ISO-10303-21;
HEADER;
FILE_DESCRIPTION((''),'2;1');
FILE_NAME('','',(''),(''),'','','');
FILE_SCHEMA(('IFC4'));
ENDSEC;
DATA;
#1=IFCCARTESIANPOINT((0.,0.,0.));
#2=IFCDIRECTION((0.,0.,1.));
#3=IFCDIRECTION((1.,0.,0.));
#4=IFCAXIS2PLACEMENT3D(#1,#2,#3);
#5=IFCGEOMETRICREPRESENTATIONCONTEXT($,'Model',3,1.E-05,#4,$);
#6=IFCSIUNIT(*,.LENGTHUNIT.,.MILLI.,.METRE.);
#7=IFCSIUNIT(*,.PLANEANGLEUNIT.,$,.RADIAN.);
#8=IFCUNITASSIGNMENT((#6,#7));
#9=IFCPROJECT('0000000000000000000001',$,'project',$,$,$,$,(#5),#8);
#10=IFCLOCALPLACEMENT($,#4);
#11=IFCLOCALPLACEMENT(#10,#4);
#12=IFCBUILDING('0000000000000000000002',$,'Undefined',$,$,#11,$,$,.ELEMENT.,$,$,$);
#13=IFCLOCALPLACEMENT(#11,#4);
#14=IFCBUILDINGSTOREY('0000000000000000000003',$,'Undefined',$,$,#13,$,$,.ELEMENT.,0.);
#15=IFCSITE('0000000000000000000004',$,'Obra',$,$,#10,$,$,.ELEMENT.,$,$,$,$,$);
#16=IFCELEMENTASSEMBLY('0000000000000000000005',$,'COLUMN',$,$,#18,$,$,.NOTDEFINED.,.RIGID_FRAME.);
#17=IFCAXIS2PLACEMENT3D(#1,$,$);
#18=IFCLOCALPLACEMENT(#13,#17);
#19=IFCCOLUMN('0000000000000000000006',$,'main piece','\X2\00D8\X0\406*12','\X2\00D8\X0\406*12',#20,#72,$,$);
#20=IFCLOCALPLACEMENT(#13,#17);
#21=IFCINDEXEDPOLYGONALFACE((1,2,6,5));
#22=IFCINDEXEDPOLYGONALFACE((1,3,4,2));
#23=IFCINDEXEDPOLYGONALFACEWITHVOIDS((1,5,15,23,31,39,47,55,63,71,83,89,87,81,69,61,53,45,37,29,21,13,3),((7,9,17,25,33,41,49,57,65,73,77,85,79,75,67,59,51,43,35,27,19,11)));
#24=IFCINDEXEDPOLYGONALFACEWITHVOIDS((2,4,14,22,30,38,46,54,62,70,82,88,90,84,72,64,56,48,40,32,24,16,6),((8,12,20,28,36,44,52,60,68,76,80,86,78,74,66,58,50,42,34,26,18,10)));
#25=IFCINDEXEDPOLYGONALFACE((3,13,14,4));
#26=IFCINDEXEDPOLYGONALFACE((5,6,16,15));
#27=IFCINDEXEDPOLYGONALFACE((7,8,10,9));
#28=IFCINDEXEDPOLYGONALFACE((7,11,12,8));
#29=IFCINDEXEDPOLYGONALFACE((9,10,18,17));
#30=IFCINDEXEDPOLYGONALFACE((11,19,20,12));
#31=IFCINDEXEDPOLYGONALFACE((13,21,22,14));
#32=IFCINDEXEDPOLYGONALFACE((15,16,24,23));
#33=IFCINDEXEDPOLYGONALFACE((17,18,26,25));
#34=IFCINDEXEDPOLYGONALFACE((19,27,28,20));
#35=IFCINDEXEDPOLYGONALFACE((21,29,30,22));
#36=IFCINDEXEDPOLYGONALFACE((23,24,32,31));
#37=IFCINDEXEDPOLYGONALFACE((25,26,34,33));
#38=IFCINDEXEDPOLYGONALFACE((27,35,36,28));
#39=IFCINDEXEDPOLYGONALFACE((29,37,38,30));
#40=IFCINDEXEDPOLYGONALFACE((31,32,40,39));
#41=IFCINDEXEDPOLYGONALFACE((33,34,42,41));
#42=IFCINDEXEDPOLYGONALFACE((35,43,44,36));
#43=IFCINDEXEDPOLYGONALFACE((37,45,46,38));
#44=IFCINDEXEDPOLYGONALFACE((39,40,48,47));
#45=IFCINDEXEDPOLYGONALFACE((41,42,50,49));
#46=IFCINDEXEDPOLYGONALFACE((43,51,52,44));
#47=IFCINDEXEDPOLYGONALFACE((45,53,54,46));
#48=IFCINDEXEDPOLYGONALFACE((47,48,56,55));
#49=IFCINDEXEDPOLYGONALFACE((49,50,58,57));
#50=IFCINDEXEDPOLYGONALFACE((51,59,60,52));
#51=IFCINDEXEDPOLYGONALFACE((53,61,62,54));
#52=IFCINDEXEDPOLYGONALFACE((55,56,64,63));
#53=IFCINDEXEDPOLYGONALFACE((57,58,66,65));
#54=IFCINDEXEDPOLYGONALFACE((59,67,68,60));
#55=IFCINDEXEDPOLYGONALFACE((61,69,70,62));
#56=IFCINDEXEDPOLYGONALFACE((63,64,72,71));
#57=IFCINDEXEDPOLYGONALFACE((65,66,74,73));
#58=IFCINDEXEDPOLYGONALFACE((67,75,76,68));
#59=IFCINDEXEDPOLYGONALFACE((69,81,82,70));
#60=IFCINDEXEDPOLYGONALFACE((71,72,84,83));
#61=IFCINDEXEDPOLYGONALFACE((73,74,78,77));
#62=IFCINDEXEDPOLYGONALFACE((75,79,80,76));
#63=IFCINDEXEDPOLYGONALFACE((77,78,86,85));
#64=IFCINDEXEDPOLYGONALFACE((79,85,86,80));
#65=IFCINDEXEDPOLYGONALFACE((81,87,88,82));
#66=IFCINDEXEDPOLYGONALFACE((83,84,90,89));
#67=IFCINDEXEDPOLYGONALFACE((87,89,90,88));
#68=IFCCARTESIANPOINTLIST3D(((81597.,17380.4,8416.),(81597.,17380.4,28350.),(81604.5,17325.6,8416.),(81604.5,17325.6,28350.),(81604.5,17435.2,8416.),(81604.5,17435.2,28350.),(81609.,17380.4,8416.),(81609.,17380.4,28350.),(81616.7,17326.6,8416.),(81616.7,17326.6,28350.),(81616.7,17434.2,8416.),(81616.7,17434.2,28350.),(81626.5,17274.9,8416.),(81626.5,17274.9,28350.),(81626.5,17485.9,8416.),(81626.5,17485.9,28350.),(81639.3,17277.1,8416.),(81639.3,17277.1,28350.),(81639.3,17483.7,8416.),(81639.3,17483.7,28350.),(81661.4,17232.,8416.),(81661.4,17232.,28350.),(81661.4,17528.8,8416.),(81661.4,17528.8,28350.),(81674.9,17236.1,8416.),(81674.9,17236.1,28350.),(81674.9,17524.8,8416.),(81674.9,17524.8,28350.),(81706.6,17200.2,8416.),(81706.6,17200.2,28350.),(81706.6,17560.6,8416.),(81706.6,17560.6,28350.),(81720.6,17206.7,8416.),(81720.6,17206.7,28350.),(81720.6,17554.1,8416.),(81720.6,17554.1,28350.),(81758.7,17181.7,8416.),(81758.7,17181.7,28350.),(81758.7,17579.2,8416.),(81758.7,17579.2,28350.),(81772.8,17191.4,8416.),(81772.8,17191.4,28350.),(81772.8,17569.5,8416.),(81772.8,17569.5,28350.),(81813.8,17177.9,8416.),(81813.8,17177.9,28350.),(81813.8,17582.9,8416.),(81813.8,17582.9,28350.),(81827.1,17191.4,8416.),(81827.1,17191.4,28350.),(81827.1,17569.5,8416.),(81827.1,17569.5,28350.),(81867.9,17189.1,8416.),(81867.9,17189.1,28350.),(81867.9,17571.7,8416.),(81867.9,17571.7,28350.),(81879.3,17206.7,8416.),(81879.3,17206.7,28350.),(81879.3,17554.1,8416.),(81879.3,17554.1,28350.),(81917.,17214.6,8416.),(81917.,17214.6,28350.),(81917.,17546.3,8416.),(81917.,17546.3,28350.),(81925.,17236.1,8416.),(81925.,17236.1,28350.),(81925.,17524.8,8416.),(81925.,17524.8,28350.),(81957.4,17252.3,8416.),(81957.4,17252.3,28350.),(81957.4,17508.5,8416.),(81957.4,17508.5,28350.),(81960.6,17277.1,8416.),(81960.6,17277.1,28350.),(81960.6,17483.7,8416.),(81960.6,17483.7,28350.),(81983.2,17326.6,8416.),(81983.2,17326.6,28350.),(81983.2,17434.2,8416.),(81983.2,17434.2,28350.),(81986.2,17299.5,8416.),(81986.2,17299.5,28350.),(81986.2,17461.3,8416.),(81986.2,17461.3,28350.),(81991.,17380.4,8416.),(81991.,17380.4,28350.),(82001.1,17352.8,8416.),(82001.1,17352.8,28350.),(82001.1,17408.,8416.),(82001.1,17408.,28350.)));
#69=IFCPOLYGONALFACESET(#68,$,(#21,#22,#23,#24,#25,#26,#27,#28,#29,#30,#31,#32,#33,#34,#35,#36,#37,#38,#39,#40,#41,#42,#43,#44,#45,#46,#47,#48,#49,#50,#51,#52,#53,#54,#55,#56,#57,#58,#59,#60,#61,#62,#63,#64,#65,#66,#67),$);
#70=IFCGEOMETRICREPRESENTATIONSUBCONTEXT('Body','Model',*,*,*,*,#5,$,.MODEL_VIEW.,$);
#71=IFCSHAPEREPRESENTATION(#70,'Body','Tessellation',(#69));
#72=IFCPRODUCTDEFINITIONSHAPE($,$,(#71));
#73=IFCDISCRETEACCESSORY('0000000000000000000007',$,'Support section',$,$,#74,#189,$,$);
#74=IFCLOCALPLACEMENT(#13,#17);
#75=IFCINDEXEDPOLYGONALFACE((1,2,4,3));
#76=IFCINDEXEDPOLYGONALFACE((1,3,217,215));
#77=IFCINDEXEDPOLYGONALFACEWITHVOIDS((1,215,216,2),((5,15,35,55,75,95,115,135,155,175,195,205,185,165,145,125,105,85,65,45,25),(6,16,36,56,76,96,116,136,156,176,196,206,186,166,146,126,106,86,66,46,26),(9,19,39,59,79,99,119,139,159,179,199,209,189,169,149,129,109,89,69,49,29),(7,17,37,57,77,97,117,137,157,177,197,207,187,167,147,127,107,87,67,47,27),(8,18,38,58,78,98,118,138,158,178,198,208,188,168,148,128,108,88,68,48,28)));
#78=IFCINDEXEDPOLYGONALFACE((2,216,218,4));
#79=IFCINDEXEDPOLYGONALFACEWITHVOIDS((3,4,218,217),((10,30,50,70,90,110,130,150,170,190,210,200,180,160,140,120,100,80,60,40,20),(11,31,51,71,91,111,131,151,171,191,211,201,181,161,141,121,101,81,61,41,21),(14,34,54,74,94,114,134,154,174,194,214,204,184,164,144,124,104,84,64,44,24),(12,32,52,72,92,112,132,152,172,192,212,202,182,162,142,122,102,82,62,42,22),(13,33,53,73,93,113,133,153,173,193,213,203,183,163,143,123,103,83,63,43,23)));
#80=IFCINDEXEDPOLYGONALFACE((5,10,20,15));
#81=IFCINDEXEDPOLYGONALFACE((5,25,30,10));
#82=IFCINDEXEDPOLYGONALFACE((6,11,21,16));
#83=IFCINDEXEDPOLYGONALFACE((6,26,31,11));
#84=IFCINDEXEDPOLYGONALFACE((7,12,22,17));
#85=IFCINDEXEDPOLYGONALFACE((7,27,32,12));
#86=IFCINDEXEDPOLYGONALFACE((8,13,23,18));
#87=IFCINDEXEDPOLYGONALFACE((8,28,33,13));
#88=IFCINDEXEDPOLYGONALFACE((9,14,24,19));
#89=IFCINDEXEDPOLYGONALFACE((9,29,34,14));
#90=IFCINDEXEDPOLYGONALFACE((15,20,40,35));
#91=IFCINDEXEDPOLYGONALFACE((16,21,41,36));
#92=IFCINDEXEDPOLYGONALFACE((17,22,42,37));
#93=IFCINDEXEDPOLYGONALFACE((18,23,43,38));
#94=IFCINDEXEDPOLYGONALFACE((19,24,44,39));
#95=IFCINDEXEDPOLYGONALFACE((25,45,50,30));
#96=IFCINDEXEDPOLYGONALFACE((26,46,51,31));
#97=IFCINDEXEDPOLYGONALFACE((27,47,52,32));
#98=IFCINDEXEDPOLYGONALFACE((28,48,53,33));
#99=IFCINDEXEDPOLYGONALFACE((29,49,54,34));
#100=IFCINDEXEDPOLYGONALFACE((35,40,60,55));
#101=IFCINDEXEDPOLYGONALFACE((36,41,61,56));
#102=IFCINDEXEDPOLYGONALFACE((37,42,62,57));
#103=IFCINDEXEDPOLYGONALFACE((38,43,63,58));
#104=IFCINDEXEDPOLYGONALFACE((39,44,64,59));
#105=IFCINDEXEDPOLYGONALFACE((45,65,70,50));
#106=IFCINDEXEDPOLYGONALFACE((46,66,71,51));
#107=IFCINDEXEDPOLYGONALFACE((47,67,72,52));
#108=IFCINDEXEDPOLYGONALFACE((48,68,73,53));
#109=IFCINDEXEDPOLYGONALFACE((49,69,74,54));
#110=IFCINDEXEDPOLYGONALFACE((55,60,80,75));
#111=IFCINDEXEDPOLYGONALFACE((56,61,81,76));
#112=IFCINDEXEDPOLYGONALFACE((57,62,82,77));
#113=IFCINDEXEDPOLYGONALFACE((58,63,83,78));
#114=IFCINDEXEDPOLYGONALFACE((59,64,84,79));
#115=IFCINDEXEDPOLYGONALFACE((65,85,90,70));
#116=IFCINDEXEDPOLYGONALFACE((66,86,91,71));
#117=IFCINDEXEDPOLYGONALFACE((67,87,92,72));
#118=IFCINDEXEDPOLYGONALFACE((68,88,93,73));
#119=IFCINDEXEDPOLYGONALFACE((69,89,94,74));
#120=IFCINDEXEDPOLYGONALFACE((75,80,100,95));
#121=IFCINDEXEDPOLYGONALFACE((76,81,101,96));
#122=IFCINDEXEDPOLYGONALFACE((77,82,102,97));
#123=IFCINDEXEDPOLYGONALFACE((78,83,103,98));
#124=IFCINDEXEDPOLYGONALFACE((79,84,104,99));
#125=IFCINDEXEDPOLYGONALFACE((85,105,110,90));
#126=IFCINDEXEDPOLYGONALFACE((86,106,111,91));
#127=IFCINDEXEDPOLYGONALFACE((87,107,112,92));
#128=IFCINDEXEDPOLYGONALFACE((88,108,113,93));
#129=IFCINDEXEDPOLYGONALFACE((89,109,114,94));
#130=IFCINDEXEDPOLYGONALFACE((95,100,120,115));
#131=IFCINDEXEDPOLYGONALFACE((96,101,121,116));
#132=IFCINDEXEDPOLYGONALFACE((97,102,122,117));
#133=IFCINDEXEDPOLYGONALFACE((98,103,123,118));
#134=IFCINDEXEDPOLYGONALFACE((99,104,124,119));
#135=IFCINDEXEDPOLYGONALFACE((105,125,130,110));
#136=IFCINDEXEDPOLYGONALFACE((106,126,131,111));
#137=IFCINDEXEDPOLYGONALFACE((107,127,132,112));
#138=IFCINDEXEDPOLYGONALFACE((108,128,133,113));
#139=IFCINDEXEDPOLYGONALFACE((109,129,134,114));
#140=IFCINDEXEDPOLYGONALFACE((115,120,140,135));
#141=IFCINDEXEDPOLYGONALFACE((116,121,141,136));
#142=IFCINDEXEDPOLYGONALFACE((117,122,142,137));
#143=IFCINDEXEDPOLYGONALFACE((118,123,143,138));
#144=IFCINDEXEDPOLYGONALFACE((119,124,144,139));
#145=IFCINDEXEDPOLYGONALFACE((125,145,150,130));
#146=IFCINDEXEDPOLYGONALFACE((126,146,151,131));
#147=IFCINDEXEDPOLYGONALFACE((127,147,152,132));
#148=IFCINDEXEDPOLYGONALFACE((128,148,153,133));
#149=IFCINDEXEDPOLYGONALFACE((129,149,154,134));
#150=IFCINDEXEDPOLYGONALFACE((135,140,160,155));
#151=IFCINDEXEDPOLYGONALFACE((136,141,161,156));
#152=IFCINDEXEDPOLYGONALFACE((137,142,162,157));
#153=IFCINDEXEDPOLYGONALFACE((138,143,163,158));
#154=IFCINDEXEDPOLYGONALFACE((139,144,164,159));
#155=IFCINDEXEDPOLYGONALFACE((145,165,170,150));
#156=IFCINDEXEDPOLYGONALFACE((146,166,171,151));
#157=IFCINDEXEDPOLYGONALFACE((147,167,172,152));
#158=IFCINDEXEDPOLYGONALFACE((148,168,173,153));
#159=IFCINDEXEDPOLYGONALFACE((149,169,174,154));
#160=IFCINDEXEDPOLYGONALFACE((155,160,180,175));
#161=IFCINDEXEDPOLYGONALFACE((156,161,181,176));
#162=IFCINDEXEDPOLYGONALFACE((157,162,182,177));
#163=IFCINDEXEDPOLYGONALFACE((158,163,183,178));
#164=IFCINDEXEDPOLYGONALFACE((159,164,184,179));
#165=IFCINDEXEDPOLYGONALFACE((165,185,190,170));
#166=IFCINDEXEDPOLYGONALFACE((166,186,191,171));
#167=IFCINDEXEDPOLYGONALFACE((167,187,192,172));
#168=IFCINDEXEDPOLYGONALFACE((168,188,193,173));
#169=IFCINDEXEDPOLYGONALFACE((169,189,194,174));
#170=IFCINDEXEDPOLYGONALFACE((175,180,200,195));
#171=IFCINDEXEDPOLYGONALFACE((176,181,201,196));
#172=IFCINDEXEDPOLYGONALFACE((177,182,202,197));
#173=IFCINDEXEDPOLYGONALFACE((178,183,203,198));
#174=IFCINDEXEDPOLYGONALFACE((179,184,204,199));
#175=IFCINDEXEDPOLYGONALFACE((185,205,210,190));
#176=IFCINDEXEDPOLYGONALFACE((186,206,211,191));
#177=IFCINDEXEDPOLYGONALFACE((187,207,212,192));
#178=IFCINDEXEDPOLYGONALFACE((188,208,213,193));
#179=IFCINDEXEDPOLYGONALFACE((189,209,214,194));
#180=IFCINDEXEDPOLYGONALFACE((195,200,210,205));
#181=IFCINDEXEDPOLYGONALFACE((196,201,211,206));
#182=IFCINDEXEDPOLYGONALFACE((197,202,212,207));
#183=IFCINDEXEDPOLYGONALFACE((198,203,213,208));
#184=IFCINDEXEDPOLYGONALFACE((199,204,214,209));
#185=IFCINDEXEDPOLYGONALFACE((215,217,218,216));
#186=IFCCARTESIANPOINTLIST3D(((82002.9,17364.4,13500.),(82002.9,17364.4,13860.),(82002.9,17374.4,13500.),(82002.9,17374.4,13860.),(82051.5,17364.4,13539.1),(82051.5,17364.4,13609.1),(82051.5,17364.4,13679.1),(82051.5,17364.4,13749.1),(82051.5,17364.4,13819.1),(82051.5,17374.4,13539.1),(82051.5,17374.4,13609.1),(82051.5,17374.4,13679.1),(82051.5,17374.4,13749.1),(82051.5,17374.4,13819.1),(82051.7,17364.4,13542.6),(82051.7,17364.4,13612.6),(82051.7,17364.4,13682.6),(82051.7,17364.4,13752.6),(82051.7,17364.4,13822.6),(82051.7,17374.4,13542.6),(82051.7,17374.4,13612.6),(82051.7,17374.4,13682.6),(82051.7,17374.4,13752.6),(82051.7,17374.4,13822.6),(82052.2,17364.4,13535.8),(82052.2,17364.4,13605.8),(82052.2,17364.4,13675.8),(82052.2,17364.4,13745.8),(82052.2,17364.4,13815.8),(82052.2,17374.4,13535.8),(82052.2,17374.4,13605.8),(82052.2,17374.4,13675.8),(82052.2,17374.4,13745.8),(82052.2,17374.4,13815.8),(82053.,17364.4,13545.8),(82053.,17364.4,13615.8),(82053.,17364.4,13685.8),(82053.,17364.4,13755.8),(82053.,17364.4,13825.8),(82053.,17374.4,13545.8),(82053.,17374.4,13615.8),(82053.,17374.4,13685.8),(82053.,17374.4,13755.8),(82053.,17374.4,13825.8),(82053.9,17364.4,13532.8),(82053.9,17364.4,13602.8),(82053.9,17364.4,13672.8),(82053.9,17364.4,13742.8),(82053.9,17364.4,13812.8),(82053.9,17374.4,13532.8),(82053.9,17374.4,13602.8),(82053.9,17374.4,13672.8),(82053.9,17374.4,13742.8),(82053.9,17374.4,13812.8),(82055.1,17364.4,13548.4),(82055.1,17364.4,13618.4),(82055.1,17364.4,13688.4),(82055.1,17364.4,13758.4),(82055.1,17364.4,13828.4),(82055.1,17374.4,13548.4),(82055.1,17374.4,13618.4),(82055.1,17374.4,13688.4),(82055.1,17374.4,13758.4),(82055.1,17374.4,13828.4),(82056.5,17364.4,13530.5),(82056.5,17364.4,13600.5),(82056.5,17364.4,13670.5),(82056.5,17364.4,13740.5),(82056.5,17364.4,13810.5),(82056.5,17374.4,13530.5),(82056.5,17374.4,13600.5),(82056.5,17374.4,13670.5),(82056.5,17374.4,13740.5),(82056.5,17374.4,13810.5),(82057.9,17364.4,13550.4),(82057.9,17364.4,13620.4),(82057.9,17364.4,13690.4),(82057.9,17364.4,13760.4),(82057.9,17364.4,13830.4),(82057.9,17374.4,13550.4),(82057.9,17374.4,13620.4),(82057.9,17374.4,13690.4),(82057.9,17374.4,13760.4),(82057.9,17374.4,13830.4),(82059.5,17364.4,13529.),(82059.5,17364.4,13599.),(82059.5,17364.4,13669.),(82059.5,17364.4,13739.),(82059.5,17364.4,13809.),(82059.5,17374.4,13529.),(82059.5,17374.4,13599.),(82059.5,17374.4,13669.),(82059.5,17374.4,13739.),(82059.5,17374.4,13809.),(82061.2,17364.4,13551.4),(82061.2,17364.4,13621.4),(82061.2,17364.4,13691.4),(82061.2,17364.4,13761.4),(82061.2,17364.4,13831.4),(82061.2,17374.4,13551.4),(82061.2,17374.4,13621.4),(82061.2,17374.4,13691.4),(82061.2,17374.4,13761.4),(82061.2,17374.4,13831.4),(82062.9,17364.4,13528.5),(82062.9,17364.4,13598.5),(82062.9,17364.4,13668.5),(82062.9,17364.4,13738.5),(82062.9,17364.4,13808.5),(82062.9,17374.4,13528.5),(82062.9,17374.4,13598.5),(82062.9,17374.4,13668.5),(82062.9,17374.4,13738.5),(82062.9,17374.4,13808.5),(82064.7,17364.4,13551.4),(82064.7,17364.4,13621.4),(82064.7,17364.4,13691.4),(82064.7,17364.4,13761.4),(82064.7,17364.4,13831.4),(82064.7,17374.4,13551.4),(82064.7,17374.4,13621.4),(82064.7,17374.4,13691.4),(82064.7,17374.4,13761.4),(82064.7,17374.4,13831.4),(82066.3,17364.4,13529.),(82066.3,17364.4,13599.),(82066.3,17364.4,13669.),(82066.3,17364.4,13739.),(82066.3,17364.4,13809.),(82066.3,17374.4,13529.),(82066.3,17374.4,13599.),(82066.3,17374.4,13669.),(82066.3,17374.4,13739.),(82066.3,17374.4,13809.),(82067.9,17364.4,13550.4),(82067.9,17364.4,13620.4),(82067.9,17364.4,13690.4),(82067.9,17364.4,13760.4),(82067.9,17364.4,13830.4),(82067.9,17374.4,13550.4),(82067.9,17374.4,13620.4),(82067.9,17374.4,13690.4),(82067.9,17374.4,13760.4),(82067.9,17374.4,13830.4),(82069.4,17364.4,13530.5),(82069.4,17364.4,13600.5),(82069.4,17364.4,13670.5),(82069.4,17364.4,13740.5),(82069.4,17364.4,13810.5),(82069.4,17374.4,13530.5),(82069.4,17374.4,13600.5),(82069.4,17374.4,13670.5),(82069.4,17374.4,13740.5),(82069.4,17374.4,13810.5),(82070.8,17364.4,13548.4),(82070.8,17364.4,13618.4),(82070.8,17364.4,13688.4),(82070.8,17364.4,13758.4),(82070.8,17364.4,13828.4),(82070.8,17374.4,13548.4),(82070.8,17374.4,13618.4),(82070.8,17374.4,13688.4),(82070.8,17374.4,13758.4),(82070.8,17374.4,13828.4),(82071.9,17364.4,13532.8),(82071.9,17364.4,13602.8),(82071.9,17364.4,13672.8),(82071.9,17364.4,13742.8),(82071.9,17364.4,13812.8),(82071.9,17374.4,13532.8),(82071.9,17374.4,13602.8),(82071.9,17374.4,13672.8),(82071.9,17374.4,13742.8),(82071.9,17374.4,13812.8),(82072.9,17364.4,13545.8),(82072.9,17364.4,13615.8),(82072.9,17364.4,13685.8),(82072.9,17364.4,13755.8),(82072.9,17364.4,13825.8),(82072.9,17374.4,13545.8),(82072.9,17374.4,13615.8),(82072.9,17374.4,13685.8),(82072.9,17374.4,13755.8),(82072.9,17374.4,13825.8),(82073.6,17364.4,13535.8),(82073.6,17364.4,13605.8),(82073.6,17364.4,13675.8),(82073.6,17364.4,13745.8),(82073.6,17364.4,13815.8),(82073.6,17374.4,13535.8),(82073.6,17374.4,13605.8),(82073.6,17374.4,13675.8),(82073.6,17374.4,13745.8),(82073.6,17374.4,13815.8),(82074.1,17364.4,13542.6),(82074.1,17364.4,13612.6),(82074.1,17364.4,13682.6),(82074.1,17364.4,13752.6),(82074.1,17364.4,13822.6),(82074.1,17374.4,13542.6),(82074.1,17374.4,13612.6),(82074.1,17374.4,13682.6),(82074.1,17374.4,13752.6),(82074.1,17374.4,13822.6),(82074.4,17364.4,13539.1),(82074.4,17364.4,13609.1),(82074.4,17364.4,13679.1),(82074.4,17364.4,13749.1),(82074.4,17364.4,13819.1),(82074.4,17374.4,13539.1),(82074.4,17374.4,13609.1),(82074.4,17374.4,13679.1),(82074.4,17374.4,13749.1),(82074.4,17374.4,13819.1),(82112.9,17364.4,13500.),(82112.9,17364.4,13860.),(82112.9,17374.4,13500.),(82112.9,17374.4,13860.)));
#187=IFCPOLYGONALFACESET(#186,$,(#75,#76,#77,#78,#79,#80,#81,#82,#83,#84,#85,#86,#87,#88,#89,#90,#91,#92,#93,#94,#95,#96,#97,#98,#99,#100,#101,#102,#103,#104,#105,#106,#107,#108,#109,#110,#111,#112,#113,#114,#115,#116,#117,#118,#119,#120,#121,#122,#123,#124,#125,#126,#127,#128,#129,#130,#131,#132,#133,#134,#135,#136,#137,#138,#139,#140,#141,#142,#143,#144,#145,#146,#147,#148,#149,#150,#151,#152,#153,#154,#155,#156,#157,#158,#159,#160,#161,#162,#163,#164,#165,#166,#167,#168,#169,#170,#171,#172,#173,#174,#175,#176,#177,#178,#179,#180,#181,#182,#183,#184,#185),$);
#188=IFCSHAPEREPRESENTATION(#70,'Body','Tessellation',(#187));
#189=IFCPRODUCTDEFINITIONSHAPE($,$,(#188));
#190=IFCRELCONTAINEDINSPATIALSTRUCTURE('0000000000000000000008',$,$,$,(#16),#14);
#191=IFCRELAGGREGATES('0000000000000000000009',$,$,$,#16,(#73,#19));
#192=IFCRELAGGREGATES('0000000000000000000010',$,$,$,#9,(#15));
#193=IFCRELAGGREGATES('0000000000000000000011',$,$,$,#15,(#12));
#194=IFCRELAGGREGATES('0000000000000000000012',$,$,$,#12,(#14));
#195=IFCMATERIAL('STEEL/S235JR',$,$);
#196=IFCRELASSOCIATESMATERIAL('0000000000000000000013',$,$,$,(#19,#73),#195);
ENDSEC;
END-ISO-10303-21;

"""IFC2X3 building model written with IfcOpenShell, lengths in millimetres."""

from ifc_helpers import new_model, si_unit, frame, origin_with_axes, origin_2d_with_axis, place, context, subcontext, project, spatial, rectangle, circle, hollow_circle, extrude, clip, halfspace, source, transform, mapped, material, element, aggregate, save


model = new_model("IFC2X3")

# Units and contexts
model_context = context("Model", 3, precision=1e-05, world=origin_with_axes())
body_context = subcontext(model_context, "Body", "Model", "MODEL_VIEW")
ifc_project = project(units=[si_unit("LENGTHUNIT", "METRE", prefix="MILLI"), si_unit("PLANEANGLEUNIT", "RADIAN")], contexts=[model_context])

# Site, building, storey
site_placement = place(None, origin_with_axes())
site = spatial("IfcSite", under=ifc_project, at=site_placement, Name="Obra", CompositionType="ELEMENT")
building_placement = place(site_placement, origin_with_axes())
building = spatial("IfcBuilding", under=site, at=building_placement, Name="Undefined", CompositionType="ELEMENT")
storey_placement = place(building_placement, origin_with_axes())
storey = spatial("IfcBuildingStorey", under=building, at=storey_placement, Name="Undefined", CompositionType="ELEMENT", Elevation=0.0)

# Element assembly, column
assembly_1_placement = place(storey_placement, origin_with_axes())
assembly_1 = element("IfcElementAssembly", 1, at=assembly_1_placement, inside=storey, Name="COLUMN", AssemblyPlace="NOTDEFINED", PredefinedType="RIGID_FRAME")
ifc_material_1 = material(Name="STEEL/S235JR")
column_placement = place(assembly_1_placement, frame((81800.0, 17380.4, 8400.0), z_axis=(0.0, 0.0, 1.0), x_axis=(0.0, 1.0, 0.0)))
column = element("IfcColumn", 2, at=column_placement, material=ifc_material_1, Name="main piece", Description="Ø406*12", ObjectType="Ø406*12", context=body_context, shape_type="Clipping", body=[
    clip(extrude(hollow_circle(Radius=203.0, WallThickness=12.0, at=origin_2d_with_axis()), frame((0.0, 0.0, 19950.0), z_axis=(0.0, 0.0, -1.0), x_axis=(0.0, 1.0, 0.0)), (0.0, 0.0, 1.0), 19934.0), halfspace(frame((-203.0, 0.0, 16.0), z_axis=(0.0, 0.0, 1.0), x_axis=(0.0, 1.0, 0.0)), True)),
])

# Discrete accessory, opening
discrete_accessory_1_placement = place(assembly_1_placement, frame((82057.9, 17369.4, 13500.0), z_axis=(0.0, 0.0, 1.0), x_axis=(-1.0, 0.0, 0.0)))
discrete_accessory_1 = element("IfcDiscreteAccessory", 3, at=discrete_accessory_1_placement, material=ifc_material_1, Name="Support section", context=body_context, shape_type="SweptSolid", body=[
    extrude(rectangle(XDim=10.0, YDim=110.0, at=origin_2d_with_axis()), frame((0.0, 0.0, 360.0), z_axis=(0.0, 0.0, -1.0), x_axis=(0.0, 1.0, 0.0)), (0.0, 0.0, 1.0), 360.0),
])
shared_shape_1 = source(origin_with_axes(), body_context, "Body", "SweptSolid", [
    extrude(circle(Radius=11.5, at=origin_2d_with_axis()), frame((0.0, -15.8, 0.0), z_axis=(0.0, 1.0, 0.0), x_axis=(1.0, 0.0, 0.0)), (0.0, 0.0, 1.0), 10.2),
])
opening_1_placement = place(assembly_1_placement, frame((82012.9, 17380.1, 13900.0), z_axis=(1.0, 0.0, 0.0), x_axis=(0.0, 0.0, -1.0)))
element("IfcOpeningElement", 4, at=opening_1_placement, cuts=discrete_accessory_1, ObjectType="Opening", context=body_context, shape_type="MappedRepresentation", body=[
    mapped(shared_shape_1, transform((80.0, 0.0, 50.0))),
    mapped(shared_shape_1, transform((150.0, 0.0, 50.0))),
    mapped(shared_shape_1, transform((220.0, 0.0, 50.0))),
    mapped(shared_shape_1, transform((290.0, 0.0, 50.0))),
    mapped(shared_shape_1, transform((360.0, 0.0, 50.0))),
])
aggregate(assembly_1, [discrete_accessory_1, column])

save(model, "model.ifc")
